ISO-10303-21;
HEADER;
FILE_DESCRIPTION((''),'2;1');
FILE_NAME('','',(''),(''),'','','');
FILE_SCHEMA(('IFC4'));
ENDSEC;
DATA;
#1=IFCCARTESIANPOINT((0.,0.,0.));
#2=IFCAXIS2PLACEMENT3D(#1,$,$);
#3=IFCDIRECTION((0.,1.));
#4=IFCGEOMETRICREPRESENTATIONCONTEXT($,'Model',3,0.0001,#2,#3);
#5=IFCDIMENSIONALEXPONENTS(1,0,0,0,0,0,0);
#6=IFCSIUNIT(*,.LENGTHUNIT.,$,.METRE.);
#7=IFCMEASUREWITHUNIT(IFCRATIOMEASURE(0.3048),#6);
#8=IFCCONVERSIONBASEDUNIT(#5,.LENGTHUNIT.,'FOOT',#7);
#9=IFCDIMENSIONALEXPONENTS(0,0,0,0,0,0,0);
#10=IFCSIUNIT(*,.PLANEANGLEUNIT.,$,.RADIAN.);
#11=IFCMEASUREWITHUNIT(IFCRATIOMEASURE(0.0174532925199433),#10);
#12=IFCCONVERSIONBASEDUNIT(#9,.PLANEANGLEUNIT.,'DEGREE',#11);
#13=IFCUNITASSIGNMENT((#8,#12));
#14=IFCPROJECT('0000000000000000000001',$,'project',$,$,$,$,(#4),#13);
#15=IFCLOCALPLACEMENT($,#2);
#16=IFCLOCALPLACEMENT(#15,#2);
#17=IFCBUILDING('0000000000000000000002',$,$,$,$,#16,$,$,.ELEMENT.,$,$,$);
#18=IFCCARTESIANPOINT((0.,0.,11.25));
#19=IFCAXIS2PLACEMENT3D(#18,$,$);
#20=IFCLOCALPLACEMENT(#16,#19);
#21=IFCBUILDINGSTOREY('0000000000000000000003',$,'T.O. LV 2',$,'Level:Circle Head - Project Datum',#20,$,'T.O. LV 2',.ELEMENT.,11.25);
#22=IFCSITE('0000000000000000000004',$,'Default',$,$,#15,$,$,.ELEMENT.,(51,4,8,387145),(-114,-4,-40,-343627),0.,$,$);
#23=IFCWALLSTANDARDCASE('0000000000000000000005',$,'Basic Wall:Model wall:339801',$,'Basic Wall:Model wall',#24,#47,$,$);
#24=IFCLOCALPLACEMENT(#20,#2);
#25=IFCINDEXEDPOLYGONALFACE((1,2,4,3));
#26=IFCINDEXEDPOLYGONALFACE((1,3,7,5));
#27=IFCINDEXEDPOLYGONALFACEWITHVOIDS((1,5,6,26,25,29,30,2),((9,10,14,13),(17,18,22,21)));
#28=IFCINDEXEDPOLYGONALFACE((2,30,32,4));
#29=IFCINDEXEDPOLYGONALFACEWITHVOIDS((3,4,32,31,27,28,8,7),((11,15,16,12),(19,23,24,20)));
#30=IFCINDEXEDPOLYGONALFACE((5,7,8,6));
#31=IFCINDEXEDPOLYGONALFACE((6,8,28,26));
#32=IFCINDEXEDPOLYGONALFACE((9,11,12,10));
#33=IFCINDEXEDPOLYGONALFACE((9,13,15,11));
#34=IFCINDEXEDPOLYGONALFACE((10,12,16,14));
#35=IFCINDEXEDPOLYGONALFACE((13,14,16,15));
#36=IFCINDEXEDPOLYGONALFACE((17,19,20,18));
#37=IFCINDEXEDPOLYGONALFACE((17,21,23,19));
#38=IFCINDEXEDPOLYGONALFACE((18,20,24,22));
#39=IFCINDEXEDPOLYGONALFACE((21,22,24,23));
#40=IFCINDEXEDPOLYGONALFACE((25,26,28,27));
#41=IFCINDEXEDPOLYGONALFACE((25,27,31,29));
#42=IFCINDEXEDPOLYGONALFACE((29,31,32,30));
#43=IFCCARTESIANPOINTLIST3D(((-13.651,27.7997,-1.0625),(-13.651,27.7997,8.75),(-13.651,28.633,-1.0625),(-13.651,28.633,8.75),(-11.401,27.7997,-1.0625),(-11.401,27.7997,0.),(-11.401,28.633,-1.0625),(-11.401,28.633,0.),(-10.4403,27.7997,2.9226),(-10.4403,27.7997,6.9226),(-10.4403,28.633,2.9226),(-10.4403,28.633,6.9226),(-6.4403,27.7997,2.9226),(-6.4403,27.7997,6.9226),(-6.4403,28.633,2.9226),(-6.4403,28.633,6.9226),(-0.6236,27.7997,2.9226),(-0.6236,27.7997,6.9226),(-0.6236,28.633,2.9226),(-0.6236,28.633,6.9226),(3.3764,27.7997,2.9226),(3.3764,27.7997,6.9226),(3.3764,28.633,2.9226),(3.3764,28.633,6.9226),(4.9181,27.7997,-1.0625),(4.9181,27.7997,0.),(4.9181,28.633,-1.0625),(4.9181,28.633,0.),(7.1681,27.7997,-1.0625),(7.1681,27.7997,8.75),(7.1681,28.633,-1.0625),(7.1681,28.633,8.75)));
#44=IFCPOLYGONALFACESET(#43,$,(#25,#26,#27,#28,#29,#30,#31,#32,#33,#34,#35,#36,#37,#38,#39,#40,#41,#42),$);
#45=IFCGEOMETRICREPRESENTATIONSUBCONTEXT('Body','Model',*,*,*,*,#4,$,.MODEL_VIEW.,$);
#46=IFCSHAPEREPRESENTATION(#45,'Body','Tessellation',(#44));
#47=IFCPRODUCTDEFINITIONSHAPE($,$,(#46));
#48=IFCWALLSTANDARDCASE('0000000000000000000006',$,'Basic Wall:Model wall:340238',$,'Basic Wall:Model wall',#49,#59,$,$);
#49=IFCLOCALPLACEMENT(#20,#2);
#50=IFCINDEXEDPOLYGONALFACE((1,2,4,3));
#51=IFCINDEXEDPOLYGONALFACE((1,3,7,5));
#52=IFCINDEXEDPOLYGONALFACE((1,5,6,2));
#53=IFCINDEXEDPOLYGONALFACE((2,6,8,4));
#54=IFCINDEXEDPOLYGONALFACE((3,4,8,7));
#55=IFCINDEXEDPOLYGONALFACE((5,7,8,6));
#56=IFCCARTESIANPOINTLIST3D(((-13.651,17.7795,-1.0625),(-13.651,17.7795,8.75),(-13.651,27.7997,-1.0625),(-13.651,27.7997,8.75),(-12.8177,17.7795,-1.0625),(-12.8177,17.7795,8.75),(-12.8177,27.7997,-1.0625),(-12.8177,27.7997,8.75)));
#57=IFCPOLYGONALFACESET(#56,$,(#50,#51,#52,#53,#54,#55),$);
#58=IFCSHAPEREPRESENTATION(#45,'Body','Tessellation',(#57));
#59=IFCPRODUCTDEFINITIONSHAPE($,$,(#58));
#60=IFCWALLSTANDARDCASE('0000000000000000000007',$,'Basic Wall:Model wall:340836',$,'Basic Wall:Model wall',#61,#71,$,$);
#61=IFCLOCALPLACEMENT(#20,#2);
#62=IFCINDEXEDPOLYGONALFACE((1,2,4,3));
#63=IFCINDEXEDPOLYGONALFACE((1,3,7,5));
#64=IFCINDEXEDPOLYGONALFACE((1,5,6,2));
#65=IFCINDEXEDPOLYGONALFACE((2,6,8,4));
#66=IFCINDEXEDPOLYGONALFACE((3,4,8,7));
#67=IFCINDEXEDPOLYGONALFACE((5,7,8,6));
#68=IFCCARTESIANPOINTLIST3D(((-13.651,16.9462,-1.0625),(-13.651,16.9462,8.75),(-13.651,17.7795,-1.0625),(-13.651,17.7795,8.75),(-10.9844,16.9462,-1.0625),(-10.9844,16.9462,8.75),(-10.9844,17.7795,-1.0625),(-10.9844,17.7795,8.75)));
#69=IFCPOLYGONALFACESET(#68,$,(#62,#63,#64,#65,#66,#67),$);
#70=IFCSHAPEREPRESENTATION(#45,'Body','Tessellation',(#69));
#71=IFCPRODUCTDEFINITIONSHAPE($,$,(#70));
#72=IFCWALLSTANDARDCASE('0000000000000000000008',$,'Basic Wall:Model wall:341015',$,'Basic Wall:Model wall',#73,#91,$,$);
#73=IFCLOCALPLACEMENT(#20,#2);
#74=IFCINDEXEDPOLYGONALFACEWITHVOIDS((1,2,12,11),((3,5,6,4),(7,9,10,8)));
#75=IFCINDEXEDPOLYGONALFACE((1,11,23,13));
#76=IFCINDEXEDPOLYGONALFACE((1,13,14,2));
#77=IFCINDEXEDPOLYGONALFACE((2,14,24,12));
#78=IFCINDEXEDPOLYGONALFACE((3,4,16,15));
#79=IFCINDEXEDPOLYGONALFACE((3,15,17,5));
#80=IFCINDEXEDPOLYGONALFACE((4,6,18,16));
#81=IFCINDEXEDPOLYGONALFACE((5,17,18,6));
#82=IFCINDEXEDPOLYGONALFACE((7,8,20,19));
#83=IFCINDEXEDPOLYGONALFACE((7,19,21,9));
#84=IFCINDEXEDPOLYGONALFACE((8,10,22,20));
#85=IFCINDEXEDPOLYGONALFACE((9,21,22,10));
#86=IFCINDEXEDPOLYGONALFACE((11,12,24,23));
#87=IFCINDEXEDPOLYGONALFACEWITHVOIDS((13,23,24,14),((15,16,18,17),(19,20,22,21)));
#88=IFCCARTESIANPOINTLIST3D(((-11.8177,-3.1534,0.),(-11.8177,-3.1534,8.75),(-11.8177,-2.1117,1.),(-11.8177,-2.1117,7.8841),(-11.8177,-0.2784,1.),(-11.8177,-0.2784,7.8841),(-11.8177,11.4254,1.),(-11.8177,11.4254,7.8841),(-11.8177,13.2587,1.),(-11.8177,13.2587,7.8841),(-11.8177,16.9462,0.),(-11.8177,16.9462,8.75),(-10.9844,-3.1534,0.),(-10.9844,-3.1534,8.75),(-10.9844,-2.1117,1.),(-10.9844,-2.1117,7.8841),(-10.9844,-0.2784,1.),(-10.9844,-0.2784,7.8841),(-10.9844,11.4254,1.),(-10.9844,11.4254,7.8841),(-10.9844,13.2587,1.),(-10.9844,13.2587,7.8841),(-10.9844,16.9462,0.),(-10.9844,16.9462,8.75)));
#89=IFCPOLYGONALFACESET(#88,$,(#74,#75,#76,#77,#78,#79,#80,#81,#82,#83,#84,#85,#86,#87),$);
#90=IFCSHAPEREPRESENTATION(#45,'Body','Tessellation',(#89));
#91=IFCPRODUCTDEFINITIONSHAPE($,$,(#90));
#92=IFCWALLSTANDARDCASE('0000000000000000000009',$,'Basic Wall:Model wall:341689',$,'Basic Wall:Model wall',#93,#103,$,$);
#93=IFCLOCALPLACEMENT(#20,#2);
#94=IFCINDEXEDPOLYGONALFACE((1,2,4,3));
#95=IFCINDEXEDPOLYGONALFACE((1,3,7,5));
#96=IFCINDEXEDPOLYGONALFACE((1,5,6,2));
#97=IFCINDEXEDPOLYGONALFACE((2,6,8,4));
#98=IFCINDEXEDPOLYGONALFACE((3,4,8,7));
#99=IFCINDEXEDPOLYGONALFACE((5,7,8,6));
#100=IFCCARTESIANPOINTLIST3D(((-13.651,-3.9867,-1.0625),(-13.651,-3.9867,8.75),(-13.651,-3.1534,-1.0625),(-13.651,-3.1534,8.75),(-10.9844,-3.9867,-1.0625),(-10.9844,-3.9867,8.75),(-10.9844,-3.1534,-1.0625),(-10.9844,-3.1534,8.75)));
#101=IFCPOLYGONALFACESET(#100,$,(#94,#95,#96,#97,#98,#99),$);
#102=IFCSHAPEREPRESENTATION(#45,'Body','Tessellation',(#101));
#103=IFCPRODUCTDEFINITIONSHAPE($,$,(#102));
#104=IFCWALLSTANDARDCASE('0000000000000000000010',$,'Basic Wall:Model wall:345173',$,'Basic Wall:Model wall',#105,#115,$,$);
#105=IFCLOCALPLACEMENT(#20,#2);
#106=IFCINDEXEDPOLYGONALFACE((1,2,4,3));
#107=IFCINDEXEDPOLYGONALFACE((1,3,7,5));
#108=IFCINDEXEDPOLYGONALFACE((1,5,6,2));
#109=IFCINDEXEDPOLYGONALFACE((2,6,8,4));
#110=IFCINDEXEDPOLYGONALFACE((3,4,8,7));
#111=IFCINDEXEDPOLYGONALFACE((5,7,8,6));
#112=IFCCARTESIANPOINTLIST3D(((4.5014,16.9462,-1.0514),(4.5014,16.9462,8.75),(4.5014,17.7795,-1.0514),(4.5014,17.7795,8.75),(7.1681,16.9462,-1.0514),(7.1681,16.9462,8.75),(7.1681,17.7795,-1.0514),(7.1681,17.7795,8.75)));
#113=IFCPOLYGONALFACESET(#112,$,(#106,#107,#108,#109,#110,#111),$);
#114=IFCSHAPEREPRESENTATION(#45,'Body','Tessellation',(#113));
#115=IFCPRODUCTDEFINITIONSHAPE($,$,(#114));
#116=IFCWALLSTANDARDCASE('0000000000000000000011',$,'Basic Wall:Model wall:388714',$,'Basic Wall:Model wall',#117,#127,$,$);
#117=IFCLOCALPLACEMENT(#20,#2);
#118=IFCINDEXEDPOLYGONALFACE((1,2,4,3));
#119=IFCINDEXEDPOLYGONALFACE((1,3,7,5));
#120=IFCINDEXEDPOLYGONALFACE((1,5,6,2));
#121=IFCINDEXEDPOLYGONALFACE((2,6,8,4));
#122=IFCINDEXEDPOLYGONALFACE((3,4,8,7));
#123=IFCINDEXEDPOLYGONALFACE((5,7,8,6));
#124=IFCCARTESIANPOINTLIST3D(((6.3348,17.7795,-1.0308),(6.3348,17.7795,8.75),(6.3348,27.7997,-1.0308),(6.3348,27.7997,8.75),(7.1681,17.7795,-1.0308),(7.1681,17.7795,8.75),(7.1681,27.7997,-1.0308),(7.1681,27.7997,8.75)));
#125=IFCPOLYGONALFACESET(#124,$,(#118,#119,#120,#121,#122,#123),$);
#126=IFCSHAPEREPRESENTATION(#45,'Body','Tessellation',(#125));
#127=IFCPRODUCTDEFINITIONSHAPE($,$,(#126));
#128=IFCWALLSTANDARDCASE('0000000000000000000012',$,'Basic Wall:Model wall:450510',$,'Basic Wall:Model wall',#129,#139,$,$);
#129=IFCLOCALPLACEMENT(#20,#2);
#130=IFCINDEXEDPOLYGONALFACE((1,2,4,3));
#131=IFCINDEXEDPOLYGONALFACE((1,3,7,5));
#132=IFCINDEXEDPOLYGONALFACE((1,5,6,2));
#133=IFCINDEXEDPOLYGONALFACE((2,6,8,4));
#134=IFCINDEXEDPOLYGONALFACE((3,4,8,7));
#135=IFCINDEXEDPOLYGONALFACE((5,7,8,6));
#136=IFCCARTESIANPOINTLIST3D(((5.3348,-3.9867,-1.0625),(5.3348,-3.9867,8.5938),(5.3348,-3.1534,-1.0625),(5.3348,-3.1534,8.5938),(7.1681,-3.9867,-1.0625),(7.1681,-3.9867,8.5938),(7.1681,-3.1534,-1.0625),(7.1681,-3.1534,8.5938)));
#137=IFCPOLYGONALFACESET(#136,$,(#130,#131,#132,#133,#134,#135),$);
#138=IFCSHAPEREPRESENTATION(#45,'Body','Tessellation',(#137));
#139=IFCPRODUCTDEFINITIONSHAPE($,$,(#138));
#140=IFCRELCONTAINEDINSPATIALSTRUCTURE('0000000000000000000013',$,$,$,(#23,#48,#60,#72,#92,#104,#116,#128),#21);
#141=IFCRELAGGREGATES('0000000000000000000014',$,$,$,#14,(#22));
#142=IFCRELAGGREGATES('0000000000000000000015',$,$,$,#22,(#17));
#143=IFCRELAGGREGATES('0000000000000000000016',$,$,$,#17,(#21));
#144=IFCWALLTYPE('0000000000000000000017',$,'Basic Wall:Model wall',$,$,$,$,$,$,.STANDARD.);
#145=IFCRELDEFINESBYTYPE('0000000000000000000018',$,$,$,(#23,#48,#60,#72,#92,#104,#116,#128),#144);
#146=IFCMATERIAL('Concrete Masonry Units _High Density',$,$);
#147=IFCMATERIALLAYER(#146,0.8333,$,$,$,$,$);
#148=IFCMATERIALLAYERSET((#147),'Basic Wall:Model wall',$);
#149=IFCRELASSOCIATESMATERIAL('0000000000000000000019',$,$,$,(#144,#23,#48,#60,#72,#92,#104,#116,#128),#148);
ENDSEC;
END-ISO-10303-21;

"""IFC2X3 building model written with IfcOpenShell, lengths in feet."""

from ifc_helpers import new_model, entity, si_unit, converted_unit, direction, frame, frame_2d, origin, place, context, subcontext, project, spatial, rectangle, extrude, material, layer, layer_set, layer_usage, type_object, element, save


model = new_model("IFC2X3")

# Units and contexts
model_context = context("Model", 3, precision=0.0001, world=origin(), true_north=direction((0.0, 1.0)))
body_context = subcontext(model_context, "Body", "Model", "MODEL_VIEW")
ifc_project = project(units=[converted_unit("LENGTHUNIT", "FOOT", entity("IfcRatioMeasure", 0.3048), si_unit("LENGTHUNIT", "METRE"), dimensions=[1, 0, 0, 0, 0, 0, 0]), converted_unit("PLANEANGLEUNIT", "DEGREE", entity("IfcRatioMeasure", 0.0174532925199433), si_unit("PLANEANGLEUNIT", "RADIAN"), dimensions=[0, 0, 0, 0, 0, 0, 0])], contexts=[model_context])

# Site, building, storey
site_placement = place(None, origin())
site = spatial("IfcSite", under=ifc_project, at=site_placement, Name="Default", CompositionType="ELEMENT", RefLatitude=(51, 4, 8, 387145), RefLongitude=(-114, -4, -40, -343627), RefElevation=0.0)
building_placement = place(site_placement, origin())
building = spatial("IfcBuilding", under=site, at=building_placement, CompositionType="ELEMENT")
storey_placement = place(building_placement, frame((0.0, 0.0, 11.25)))
storey = spatial("IfcBuildingStorey", under=building, at=storey_placement, Name="T.O. LV 2", ObjectType="Level:Circle Head - Project Datum", LongName="T.O. LV 2", CompositionType="ELEMENT", Elevation=11.25)

# Wall, openings
ifc_material_1 = material(Name="Concrete Masonry Units _High Density")
ifc_layer_1 = layer(ifc_material_1, 0.8333)
ifc_layer_set_1 = layer_set([ifc_layer_1], Name="Basic Wall:Model wall")
ifc_layer_usage_1 = layer_usage(ifc_layer_set_1, "AXIS2", "NEGATIVE", 0.4167)
wall_type_1 = type_object("IfcWallType", Name="Basic Wall:Model wall", PredefinedType="STANDARD", material=ifc_layer_set_1)
wall_1_placement = place(storey_placement, frame((-13.651, 28.2164, -1.0625)))
wall_1 = element("IfcWallStandardCase", 1, at=wall_1_placement, inside=storey, type_object=wall_type_1, material=ifc_layer_usage_1, Name="Basic Wall:Model wall:339801", ObjectType="Basic Wall:Model wall", context=body_context, shape_type="SweptSolid", body=[
    extrude(rectangle(XDim=20.8192, YDim=0.8333, at=frame_2d((10.4096, 0.0), x_axis=(-1.0, 0.0))), origin(), (0.0, 0.0, 1.0), 9.8125),
])
opening_1_placement = place(wall_1_placement, origin())
element("IfcOpeningElement", 2, at=opening_1_placement, cuts=wall_1, ObjectType="Opening", context=body_context, shape_type="SweptSolid", body=[
    extrude(rectangle(XDim=1.0625, YDim=16.3192, at=frame_2d((0.0, 0.0), x_axis=(0.0, 1.0))), frame((10.4096, 0.4167, 0.5312), z_axis=(0.0, -1.0, 0.0), x_axis=(1.0, 0.0, 0.0)), (0.0, 0.0, 1.0), 0.8333),
])
opening_2_placement = place(wall_1_placement, frame((3.2108, -0.4167, 3.9851)))
element("IfcOpeningElement", 3, at=opening_2_placement, cuts=wall_1, ObjectType="Opening", context=body_context, shape_type="SweptSolid", body=[
    extrude(rectangle(XDim=4.0, YDim=4.0, at=frame_2d((2.0, 2.0), x_axis=(-1.0, 0.0))), frame((0.0, 0.0, 0.0), z_axis=(0.0, 1.0, 0.0), x_axis=(0.0, 0.0, 1.0)), (0.0, 0.0, 1.0), 0.8333),
])
opening_3_placement = place(wall_1_placement, frame((13.0275, -0.4167, 3.9851)))
element("IfcOpeningElement", 4, at=opening_3_placement, cuts=wall_1, ObjectType="Opening", context=body_context, shape_type="SweptSolid", body=[
    extrude(rectangle(XDim=4.0, YDim=4.0, at=frame_2d((2.0, 2.0), x_axis=(-1.0, 0.0))), frame((0.0, 0.0, 0.0), z_axis=(0.0, 1.0, 0.0), x_axis=(0.0, 0.0, 1.0)), (0.0, 0.0, 1.0), 0.8333),
])

# Walls
ifc_layer_usage_2 = layer_usage(ifc_layer_set_1, "AXIS2", "NEGATIVE", 0.4167)
wall_2_placement = place(storey_placement, frame((-13.2344, 27.7997, -1.0625), z_axis=(0.0, 0.0, 1.0), x_axis=(0.0, -1.0, 0.0)))
element("IfcWallStandardCase", 5, at=wall_2_placement, inside=storey, type_object=wall_type_1, material=ifc_layer_usage_2, Name="Basic Wall:Model wall:340238", ObjectType="Basic Wall:Model wall", context=body_context, shape_type="SweptSolid", body=[
    extrude(rectangle(XDim=10.0202, YDim=0.8333, at=frame_2d((5.0101, 0.0), x_axis=(-1.0, 0.0))), origin(), (0.0, 0.0, 1.0), 9.8125),
])
ifc_layer_usage_3 = layer_usage(ifc_layer_set_1, "AXIS2", "NEGATIVE", 0.4167)
wall_3_placement = place(storey_placement, frame((-13.651, 17.3629, -1.0625)))
element("IfcWallStandardCase", 6, at=wall_3_placement, inside=storey, type_object=wall_type_1, material=ifc_layer_usage_3, Name="Basic Wall:Model wall:340836", ObjectType="Basic Wall:Model wall", context=body_context, shape_type="SweptSolid", body=[
    extrude(rectangle(XDim=2.6667, YDim=0.8333, at=frame_2d((1.3333, 0.0), x_axis=(-1.0, 0.0))), origin(), (0.0, 0.0, 1.0), 9.8125),
])

# Wall, openings
ifc_layer_usage_4 = layer_usage(ifc_layer_set_1, "AXIS2", "NEGATIVE", 0.4167)
wall_4_placement = place(storey_placement, frame((-11.401, 16.9462, 0.0), z_axis=(0.0, 0.0, 1.0), x_axis=(0.0, -1.0, 0.0)))
wall_4 = element("IfcWallStandardCase", 7, at=wall_4_placement, inside=storey, type_object=wall_type_1, material=ifc_layer_usage_4, Name="Basic Wall:Model wall:341015", ObjectType="Basic Wall:Model wall", context=body_context, shape_type="SweptSolid", body=[
    extrude(rectangle(XDim=20.0996, YDim=0.8333, at=frame_2d((10.0498, 0.0), x_axis=(-1.0, 0.0))), origin(), (0.0, 0.0, 1.0), 8.75),
])
opening_4_placement = place(wall_4_placement, frame((17.2246, -0.4167, 1.0)))
element("IfcOpeningElement", 8, at=opening_4_placement, cuts=wall_4, ObjectType="Opening", context=body_context, shape_type="SweptSolid", body=[
    extrude(rectangle(XDim=6.8841, YDim=1.8333, at=frame_2d((3.4421, 0.9167), x_axis=(-1.0, 0.0))), frame((0.0, 0.0, 0.0), z_axis=(0.0, 1.0, 0.0), x_axis=(0.0, 0.0, 1.0)), (0.0, 0.0, 1.0), 0.8333),
])
opening_5_placement = place(wall_4_placement, frame((3.6875, -0.4167, 1.0)))
element("IfcOpeningElement", 9, at=opening_5_placement, cuts=wall_4, ObjectType="Opening", context=body_context, shape_type="SweptSolid", body=[
    extrude(rectangle(XDim=6.8841, YDim=1.8333, at=frame_2d((3.4421, 0.9167), x_axis=(-1.0, 0.0))), frame((0.0, 0.0, 0.0), z_axis=(0.0, 1.0, 0.0), x_axis=(0.0, 0.0, 1.0)), (0.0, 0.0, 1.0), 0.8333),
])

# Walls
ifc_layer_usage_5 = layer_usage(ifc_layer_set_1, "AXIS2", "NEGATIVE", 0.4167)
wall_5_placement = place(storey_placement, frame((-13.651, -3.5701, -1.0625)))
element("IfcWallStandardCase", 10, at=wall_5_placement, inside=storey, type_object=wall_type_1, material=ifc_layer_usage_5, Name="Basic Wall:Model wall:341689", ObjectType="Basic Wall:Model wall", context=body_context, shape_type="SweptSolid", body=[
    extrude(rectangle(XDim=2.6667, YDim=0.8333, at=frame_2d((1.3333, 0.0), x_axis=(-1.0, 0.0))), origin(), (0.0, 0.0, 1.0), 9.8125),
])
ifc_layer_usage_6 = layer_usage(ifc_layer_set_1, "AXIS2", "NEGATIVE", 0.4167)
wall_6_placement = place(storey_placement, frame((4.5014, 17.3629, -1.0514)))
element("IfcWallStandardCase", 11, at=wall_6_placement, inside=storey, type_object=wall_type_1, material=ifc_layer_usage_6, Name="Basic Wall:Model wall:345173", ObjectType="Basic Wall:Model wall", context=body_context, shape_type="SweptSolid", body=[
    extrude(rectangle(XDim=2.6667, YDim=0.8333, at=frame_2d((1.3333, 0.0), x_axis=(-1.0, 0.0))), origin(), (0.0, 0.0, 1.0), 9.8014),
])
ifc_layer_usage_7 = layer_usage(ifc_layer_set_1, "AXIS2", "NEGATIVE", 0.4167)
wall_7_placement = place(storey_placement, frame((6.7514, 27.7997, -1.0308), z_axis=(0.0, 0.0, 1.0), x_axis=(0.0, -1.0, 0.0)))
element("IfcWallStandardCase", 12, at=wall_7_placement, inside=storey, type_object=wall_type_1, material=ifc_layer_usage_7, Name="Basic Wall:Model wall:388714", ObjectType="Basic Wall:Model wall", context=body_context, shape_type="SweptSolid", body=[
    extrude(rectangle(XDim=10.0202, YDim=0.8333, at=frame_2d((5.0101, 0.0), x_axis=(-1.0, 0.0))), origin(), (0.0, 0.0, 1.0), 9.7808),
])
ifc_layer_usage_8 = layer_usage(ifc_layer_set_1, "AXIS2", "NEGATIVE", 0.4167)
wall_8_placement = place(storey_placement, frame((5.3348, -3.5701, -1.0625)))
element("IfcWallStandardCase", 13, at=wall_8_placement, inside=storey, type_object=wall_type_1, material=ifc_layer_usage_8, Name="Basic Wall:Model wall:450510", ObjectType="Basic Wall:Model wall", context=body_context, shape_type="SweptSolid", body=[
    extrude(rectangle(XDim=1.8333, YDim=0.8333, at=frame_2d((0.9167, 0.0), x_axis=(-1.0, 0.0))), origin(), (0.0, 0.0, 1.0), 9.6563),
])

save(model, "model.ifc")
